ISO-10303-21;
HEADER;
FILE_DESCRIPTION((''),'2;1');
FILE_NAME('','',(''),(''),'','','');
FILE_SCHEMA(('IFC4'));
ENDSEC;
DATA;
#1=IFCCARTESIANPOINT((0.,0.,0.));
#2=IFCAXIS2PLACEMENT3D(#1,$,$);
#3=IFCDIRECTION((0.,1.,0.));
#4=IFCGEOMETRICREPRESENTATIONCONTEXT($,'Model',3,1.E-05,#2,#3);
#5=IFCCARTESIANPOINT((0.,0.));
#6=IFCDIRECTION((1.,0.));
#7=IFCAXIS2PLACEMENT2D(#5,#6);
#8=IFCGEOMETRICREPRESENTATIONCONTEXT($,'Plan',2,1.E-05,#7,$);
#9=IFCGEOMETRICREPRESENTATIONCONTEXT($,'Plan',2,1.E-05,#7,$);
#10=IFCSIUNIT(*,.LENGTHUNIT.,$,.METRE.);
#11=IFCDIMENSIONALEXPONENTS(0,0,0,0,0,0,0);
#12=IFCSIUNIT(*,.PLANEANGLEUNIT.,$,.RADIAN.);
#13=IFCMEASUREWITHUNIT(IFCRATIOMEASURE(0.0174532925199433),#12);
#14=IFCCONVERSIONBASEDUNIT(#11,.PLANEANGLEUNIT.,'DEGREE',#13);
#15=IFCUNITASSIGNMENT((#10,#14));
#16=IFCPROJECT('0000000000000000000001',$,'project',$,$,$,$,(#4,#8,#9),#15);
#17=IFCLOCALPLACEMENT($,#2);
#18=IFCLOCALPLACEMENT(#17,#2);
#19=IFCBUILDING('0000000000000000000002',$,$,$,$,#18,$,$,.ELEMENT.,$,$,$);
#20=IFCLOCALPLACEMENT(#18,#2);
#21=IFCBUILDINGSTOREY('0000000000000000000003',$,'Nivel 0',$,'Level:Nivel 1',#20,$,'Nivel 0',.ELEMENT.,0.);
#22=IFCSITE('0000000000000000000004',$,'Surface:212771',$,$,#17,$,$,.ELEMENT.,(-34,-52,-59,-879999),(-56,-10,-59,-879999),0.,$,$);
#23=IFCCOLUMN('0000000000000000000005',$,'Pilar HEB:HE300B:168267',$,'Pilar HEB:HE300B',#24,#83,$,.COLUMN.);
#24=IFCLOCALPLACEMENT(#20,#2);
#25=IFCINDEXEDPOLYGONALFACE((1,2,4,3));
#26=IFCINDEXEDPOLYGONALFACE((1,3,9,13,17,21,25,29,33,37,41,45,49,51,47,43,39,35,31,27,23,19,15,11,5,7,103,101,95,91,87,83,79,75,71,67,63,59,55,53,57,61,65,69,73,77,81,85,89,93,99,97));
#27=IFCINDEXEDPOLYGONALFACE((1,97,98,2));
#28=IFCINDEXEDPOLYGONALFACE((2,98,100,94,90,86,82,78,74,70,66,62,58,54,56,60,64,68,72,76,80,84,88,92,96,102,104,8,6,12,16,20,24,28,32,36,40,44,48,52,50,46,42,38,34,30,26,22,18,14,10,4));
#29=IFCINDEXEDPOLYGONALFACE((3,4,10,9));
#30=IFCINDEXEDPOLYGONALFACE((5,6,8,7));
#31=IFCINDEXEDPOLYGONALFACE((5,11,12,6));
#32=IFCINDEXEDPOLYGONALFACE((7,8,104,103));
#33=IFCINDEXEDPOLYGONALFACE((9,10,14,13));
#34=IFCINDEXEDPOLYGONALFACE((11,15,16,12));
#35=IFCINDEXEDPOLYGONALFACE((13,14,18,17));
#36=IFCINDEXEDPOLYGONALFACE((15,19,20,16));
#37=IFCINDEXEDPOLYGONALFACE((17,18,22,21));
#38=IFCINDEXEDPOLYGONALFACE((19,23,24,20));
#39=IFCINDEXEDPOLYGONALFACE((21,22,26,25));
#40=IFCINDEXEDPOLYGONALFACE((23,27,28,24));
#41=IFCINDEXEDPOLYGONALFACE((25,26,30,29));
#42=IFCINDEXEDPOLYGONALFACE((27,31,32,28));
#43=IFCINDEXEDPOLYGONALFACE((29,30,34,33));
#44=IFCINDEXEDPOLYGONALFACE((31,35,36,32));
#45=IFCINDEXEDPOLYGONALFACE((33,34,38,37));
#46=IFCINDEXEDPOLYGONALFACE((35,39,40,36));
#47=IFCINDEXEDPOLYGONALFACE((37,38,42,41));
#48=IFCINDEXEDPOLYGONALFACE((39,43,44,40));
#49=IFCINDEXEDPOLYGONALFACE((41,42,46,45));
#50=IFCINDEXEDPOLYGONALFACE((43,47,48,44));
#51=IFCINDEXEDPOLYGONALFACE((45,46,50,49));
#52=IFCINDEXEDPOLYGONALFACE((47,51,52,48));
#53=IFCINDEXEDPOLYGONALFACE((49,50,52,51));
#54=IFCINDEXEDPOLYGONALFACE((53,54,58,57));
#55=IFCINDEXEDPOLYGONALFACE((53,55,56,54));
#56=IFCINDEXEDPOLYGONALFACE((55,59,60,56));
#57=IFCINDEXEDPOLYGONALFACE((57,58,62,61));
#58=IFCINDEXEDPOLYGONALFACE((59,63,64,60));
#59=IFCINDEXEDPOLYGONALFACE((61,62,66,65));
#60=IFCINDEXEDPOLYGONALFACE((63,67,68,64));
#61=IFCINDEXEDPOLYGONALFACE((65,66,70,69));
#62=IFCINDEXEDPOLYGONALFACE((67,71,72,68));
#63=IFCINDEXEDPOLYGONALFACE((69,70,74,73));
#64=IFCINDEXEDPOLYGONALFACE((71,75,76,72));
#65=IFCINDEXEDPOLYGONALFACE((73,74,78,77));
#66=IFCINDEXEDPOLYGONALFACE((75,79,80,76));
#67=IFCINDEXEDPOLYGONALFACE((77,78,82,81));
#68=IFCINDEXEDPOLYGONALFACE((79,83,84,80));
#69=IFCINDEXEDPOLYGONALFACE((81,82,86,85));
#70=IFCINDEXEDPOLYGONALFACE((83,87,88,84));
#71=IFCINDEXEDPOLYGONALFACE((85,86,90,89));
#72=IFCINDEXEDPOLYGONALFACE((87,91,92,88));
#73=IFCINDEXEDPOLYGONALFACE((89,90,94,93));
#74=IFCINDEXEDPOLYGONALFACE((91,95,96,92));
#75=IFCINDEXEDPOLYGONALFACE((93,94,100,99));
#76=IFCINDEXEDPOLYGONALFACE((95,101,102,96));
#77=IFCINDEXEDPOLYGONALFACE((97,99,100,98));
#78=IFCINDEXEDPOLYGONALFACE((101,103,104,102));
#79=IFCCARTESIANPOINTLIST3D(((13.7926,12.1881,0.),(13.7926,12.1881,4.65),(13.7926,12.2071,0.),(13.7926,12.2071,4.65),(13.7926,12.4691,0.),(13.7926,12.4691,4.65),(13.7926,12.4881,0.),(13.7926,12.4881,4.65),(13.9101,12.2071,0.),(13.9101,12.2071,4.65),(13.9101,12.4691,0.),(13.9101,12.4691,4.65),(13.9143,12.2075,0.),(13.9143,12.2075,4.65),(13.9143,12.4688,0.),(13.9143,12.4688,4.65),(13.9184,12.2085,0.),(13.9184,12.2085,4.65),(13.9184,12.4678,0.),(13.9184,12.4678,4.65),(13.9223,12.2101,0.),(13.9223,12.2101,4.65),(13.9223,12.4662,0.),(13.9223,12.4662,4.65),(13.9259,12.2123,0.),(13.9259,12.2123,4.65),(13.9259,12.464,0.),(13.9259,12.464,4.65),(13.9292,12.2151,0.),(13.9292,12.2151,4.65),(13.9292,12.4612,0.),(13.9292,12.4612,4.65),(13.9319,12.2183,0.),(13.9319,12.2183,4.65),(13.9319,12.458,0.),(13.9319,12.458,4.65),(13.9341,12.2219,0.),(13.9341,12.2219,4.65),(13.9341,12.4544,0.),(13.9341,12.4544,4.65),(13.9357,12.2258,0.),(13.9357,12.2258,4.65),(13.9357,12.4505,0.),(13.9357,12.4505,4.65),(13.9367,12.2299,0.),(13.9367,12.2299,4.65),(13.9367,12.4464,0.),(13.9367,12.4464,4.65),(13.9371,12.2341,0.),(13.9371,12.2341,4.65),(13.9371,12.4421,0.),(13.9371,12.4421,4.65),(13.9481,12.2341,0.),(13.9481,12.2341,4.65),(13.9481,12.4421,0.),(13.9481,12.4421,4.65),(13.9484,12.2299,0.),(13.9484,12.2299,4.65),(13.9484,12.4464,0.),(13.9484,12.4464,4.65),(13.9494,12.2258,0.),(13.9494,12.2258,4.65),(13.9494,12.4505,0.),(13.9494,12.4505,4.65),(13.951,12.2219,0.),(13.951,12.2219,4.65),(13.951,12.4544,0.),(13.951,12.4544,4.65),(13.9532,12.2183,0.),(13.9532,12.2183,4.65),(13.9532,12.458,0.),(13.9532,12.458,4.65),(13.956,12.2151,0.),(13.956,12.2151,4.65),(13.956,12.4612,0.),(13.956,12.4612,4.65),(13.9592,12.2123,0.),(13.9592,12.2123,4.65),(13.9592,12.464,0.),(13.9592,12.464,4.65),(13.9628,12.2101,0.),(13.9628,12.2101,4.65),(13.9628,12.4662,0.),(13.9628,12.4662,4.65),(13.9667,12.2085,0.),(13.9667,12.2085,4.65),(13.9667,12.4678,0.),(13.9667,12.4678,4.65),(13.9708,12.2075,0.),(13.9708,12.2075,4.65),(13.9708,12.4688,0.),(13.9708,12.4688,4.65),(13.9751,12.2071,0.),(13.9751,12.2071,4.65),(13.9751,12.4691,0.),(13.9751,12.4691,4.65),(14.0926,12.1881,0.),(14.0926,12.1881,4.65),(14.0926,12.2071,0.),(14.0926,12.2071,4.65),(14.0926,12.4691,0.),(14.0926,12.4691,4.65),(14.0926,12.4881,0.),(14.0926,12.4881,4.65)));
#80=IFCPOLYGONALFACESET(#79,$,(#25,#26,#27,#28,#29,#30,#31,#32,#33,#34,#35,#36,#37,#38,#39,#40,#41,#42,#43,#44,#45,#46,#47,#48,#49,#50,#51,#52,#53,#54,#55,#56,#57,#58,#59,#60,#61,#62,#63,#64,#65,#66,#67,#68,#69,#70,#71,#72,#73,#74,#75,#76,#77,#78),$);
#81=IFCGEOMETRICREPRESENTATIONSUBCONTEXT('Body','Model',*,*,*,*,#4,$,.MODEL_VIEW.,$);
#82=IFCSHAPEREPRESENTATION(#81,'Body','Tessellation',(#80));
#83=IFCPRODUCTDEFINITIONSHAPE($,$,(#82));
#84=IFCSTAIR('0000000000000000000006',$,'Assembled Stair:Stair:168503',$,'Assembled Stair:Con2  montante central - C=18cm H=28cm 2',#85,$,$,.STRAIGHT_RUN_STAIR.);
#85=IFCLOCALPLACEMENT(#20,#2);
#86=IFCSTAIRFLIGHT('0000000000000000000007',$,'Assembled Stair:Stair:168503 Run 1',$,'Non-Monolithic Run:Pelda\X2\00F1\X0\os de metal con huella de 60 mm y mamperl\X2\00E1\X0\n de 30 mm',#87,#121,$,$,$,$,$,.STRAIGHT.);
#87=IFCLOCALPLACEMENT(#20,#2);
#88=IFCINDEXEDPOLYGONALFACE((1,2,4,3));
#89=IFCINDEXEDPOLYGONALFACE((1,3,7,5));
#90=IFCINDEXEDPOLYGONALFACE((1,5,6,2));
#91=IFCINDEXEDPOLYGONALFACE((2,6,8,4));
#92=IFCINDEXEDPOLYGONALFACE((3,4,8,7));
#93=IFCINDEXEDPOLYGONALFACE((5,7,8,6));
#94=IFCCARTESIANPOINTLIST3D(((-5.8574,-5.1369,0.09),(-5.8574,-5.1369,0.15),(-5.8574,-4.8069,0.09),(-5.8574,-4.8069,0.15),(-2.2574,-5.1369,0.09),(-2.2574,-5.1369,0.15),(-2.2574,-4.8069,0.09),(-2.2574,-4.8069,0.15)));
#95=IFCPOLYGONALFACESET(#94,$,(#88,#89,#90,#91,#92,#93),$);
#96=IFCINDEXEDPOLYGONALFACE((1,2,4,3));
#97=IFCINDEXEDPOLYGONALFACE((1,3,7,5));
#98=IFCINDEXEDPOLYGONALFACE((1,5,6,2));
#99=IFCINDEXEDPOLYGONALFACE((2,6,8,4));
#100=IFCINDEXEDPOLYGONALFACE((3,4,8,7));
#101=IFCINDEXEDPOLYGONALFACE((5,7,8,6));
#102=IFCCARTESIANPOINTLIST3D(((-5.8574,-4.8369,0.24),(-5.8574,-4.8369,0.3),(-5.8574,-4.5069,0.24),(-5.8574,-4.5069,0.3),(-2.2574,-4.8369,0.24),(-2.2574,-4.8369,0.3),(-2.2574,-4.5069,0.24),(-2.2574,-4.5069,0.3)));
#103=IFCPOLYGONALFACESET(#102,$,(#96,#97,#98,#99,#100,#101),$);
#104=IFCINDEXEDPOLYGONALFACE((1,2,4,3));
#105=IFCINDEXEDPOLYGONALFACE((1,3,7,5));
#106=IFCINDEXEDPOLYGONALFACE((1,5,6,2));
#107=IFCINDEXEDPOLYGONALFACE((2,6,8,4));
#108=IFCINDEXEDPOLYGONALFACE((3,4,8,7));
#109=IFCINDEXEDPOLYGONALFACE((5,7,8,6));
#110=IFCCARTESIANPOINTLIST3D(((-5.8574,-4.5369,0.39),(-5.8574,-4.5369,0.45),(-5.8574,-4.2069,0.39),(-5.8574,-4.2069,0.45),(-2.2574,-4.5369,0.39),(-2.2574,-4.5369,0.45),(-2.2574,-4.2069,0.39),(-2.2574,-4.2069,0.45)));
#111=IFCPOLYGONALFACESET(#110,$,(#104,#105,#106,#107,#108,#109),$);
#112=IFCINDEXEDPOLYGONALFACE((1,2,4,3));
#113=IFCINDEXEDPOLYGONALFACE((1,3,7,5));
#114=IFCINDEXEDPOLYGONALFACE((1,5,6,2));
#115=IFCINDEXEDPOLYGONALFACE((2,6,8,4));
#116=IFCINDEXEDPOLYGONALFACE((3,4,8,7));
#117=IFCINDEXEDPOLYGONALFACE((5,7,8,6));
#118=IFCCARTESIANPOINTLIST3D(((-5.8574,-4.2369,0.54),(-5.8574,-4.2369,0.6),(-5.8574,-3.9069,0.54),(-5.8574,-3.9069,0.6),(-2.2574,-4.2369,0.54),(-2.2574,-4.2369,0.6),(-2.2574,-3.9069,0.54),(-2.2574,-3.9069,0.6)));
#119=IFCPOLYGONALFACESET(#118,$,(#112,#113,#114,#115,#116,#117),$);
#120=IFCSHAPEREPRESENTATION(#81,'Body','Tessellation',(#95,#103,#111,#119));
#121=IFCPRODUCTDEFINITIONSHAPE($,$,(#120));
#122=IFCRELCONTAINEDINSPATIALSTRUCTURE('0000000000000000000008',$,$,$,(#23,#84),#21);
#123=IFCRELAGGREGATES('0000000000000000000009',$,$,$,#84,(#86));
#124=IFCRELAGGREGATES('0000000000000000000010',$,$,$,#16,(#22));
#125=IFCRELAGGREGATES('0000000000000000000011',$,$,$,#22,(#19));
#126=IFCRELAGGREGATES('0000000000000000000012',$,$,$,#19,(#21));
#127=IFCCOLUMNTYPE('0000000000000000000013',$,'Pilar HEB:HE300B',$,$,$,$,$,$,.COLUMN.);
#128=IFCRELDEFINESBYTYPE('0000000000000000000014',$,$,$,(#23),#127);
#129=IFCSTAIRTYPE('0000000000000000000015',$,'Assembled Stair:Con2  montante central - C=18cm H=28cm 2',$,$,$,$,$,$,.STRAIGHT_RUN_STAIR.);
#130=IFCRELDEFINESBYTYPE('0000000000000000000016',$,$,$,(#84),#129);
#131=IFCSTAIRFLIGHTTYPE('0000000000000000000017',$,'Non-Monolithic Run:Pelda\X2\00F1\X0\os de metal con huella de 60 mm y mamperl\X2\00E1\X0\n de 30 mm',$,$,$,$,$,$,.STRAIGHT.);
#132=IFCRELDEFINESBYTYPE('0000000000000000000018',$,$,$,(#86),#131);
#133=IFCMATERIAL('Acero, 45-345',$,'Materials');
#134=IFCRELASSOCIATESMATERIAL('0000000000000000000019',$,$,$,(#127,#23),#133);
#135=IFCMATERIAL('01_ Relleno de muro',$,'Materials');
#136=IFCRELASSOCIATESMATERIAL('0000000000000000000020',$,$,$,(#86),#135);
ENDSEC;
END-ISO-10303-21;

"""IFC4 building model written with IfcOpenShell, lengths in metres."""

from ifc_helpers import new_model, entity, si_unit, converted_unit, direction, frame, origin, origin_2d_with_axis, place, context, subcontext, project, spatial, indexed_curve, outline, extrude, source, transform, mapped, material, type_object, type_shapes, element, aggregate, save


model = new_model("IFC4")

# Units and contexts
model_context = context("Model", 3, precision=1e-05, world=origin(), true_north=direction((0.0, 1.0, 0.0)))
plan_context_1 = context("Plan", 2, precision=1e-05, world=origin_2d_with_axis())
plan_context_2 = context("Plan", 2, precision=1e-05, world=origin_2d_with_axis())
body_context = subcontext(model_context, "Body", "Model", "MODEL_VIEW")
ifc_project = project(units=[si_unit("LENGTHUNIT", "METRE"), converted_unit("PLANEANGLEUNIT", "DEGREE", entity("IfcRatioMeasure", 0.0174532925199433), si_unit("PLANEANGLEUNIT", "RADIAN"), dimensions=[0, 0, 0, 0, 0, 0, 0])], contexts=[model_context, plan_context_1, plan_context_2])

# Site, building, storey
site_placement = place(None, origin())
site = spatial("IfcSite", under=ifc_project, at=site_placement, Name="Surface:212771", CompositionType="ELEMENT", RefLatitude=(-34, -52, -59, -879999), RefLongitude=(-56, -10, -59, -879999), RefElevation=0.0)
building_placement = place(site_placement, origin())
building = spatial("IfcBuilding", under=site, at=building_placement, CompositionType="ELEMENT")
storey_placement = place(building_placement, origin())
storey = spatial("IfcBuildingStorey", under=building, at=storey_placement, Name="Nivel 0", ObjectType="Level:Nivel 1", LongName="Nivel 0", CompositionType="ELEMENT", Elevation=0.0)

# Column
ifc_material_1 = material(Name="Acero, 45-345", Category="Materials")
column_type_1 = type_object("IfcColumnType", Name="Pilar HEB:HE300B", PredefinedType="COLUMN", material=ifc_material_1)
shared_shape_1 = source(origin(), body_context, "Body", "SweptSolid", [
    extrude(outline(indexed_curve([(-0.15, -0.15), (-0.131, -0.15), (-0.131, -0.0325), (-0.1307, -0.0283), (-0.1297, -0.0242), (-0.1281, -0.0202), (-0.1258, -0.0166), (-0.1231, -0.0134), (-0.1199, -0.0107), (-0.1163, -0.0084), (-0.1123, -0.0068), (-0.1082, -0.0058), (-0.104, -0.0055), (0.104, -0.0055), (0.1082, -0.0058), (0.1123, -0.0068), (0.1163, -0.0084), (0.1199, -0.0107), (0.1231, -0.0134), (0.1258, -0.0166), (0.1281, -0.0202), (0.1297, -0.0242), (0.1307, -0.0283), (0.131, -0.0325), (0.131, -0.15), (0.15, -0.15), (0.15, 0.15), (0.131, 0.15), (0.131, 0.0325), (0.1307, 0.0283), (0.1297, 0.0242), (0.1281, 0.0202), (0.1258, 0.0166), (0.1231, 0.0134), (0.1199, 0.0107), (0.1163, 0.0084), (0.1123, 0.0068), (0.1082, 0.0058), (0.104, 0.0055), (-0.104, 0.0055), (-0.1082, 0.0058), (-0.1123, 0.0068), (-0.1163, 0.0084), (-0.1199, 0.0107), (-0.1231, 0.0134), (-0.1258, 0.0166), (-0.1281, 0.0202), (-0.1297, 0.0242), (-0.1307, 0.0283), (-0.131, 0.0325), (-0.131, 0.15), (-0.15, 0.15), (-0.15, -0.15)], self_intersect=False)), frame((0.0, 0.0, 0.0), z_axis=(0.0, 0.0, 1.0), x_axis=(0.0, -1.0, 0.0)), (0.0, 0.0, 1.0), 4.65),
])
type_shapes(column_type_1, [shared_shape_1])
for number, where, name in (
    (1, (13.9426, 12.3381, 0.0), "Pilar HEB:HE300B:168267"),
):
    element("IfcColumn", number, at=place(storey_placement, frame(where)), inside=storey, type_object=column_type_1, material=ifc_material_1, Name=name, ObjectType="Pilar HEB:HE300B", PredefinedType="COLUMN", context=body_context, shape_type="MappedRepresentation", body=[
        mapped(shared_shape_1, transform((0.0, 0.0, 0.0), scale=1.0)),
    ])

# Stair, stair flight
stair_type = type_object("IfcStairType", Name="Assembled Stair:Con2  montante central - C=18cm H=28cm 2", PredefinedType="STRAIGHT_RUN_STAIR")
stair_placement = place(storey_placement, origin())
stair = element("IfcStair", 2, at=stair_placement, inside=storey, type_object=stair_type, Name="Assembled Stair:Stair:168503", ObjectType="Assembled Stair:Con2  montante central - C=18cm H=28cm 2", PredefinedType="STRAIGHT_RUN_STAIR")
ifc_material_2 = material(Name="01_ Relleno de muro", Category="Materials")
stair_flight_type = type_object("IfcStairFlightType", Name="Non-Monolithic Run:Peldaños de metal con huella de 60 mm y mamperlán de 30 mm", PredefinedType="STRAIGHT")
stair_flight_placement = place(stair_placement, origin())
stair_flight = element("IfcStairFlight", 3, at=stair_flight_placement, type_object=stair_flight_type, material=ifc_material_2, Name="Assembled Stair:Stair:168503 Run 1", ObjectType="Non-Monolithic Run:Peldaños de metal con huella de 60 mm y mamperlán de 30 mm", PredefinedType="STRAIGHT", context=body_context, shape_type="SweptSolid", body=[
    extrude(outline(indexed_curve([(-0.165, -1.8), (0.165, -1.8), (0.165, 1.8), (-0.165, 1.8), (-0.165, -1.8)], self_intersect=False)), frame((-4.0574, -4.9719, 0.09), z_axis=(0.0, 0.0, 1.0), x_axis=(0.0, -1.0, 0.0)), (0.0, 0.0, 1.0), 0.06),
    extrude(outline(indexed_curve([(-0.165, -1.8), (0.165, -1.8), (0.165, 1.8), (-0.165, 1.8), (-0.165, -1.8)], self_intersect=False)), frame((-4.0574, -4.6719, 0.24), z_axis=(0.0, 0.0, 1.0), x_axis=(0.0, -1.0, 0.0)), (0.0, 0.0, 1.0), 0.06),
    extrude(outline(indexed_curve([(-0.165, -1.8), (0.165, -1.8), (0.165, 1.8), (-0.165, 1.8), (-0.165, -1.8)], self_intersect=False)), frame((-4.0574, -4.3719, 0.39), z_axis=(0.0, 0.0, 1.0), x_axis=(0.0, -1.0, 0.0)), (0.0, 0.0, 1.0), 0.06),
    extrude(outline(indexed_curve([(-0.165, -1.8), (0.165, -1.8), (0.165, 1.8), (-0.165, 1.8), (-0.165, -1.8)], self_intersect=False)), frame((-4.0574, -4.0719, 0.54), z_axis=(0.0, 0.0, 1.0), x_axis=(0.0, -1.0, 0.0)), (0.0, 0.0, 1.0), 0.06),
])
aggregate(stair, [stair_flight])

save(model, "model.ifc")
